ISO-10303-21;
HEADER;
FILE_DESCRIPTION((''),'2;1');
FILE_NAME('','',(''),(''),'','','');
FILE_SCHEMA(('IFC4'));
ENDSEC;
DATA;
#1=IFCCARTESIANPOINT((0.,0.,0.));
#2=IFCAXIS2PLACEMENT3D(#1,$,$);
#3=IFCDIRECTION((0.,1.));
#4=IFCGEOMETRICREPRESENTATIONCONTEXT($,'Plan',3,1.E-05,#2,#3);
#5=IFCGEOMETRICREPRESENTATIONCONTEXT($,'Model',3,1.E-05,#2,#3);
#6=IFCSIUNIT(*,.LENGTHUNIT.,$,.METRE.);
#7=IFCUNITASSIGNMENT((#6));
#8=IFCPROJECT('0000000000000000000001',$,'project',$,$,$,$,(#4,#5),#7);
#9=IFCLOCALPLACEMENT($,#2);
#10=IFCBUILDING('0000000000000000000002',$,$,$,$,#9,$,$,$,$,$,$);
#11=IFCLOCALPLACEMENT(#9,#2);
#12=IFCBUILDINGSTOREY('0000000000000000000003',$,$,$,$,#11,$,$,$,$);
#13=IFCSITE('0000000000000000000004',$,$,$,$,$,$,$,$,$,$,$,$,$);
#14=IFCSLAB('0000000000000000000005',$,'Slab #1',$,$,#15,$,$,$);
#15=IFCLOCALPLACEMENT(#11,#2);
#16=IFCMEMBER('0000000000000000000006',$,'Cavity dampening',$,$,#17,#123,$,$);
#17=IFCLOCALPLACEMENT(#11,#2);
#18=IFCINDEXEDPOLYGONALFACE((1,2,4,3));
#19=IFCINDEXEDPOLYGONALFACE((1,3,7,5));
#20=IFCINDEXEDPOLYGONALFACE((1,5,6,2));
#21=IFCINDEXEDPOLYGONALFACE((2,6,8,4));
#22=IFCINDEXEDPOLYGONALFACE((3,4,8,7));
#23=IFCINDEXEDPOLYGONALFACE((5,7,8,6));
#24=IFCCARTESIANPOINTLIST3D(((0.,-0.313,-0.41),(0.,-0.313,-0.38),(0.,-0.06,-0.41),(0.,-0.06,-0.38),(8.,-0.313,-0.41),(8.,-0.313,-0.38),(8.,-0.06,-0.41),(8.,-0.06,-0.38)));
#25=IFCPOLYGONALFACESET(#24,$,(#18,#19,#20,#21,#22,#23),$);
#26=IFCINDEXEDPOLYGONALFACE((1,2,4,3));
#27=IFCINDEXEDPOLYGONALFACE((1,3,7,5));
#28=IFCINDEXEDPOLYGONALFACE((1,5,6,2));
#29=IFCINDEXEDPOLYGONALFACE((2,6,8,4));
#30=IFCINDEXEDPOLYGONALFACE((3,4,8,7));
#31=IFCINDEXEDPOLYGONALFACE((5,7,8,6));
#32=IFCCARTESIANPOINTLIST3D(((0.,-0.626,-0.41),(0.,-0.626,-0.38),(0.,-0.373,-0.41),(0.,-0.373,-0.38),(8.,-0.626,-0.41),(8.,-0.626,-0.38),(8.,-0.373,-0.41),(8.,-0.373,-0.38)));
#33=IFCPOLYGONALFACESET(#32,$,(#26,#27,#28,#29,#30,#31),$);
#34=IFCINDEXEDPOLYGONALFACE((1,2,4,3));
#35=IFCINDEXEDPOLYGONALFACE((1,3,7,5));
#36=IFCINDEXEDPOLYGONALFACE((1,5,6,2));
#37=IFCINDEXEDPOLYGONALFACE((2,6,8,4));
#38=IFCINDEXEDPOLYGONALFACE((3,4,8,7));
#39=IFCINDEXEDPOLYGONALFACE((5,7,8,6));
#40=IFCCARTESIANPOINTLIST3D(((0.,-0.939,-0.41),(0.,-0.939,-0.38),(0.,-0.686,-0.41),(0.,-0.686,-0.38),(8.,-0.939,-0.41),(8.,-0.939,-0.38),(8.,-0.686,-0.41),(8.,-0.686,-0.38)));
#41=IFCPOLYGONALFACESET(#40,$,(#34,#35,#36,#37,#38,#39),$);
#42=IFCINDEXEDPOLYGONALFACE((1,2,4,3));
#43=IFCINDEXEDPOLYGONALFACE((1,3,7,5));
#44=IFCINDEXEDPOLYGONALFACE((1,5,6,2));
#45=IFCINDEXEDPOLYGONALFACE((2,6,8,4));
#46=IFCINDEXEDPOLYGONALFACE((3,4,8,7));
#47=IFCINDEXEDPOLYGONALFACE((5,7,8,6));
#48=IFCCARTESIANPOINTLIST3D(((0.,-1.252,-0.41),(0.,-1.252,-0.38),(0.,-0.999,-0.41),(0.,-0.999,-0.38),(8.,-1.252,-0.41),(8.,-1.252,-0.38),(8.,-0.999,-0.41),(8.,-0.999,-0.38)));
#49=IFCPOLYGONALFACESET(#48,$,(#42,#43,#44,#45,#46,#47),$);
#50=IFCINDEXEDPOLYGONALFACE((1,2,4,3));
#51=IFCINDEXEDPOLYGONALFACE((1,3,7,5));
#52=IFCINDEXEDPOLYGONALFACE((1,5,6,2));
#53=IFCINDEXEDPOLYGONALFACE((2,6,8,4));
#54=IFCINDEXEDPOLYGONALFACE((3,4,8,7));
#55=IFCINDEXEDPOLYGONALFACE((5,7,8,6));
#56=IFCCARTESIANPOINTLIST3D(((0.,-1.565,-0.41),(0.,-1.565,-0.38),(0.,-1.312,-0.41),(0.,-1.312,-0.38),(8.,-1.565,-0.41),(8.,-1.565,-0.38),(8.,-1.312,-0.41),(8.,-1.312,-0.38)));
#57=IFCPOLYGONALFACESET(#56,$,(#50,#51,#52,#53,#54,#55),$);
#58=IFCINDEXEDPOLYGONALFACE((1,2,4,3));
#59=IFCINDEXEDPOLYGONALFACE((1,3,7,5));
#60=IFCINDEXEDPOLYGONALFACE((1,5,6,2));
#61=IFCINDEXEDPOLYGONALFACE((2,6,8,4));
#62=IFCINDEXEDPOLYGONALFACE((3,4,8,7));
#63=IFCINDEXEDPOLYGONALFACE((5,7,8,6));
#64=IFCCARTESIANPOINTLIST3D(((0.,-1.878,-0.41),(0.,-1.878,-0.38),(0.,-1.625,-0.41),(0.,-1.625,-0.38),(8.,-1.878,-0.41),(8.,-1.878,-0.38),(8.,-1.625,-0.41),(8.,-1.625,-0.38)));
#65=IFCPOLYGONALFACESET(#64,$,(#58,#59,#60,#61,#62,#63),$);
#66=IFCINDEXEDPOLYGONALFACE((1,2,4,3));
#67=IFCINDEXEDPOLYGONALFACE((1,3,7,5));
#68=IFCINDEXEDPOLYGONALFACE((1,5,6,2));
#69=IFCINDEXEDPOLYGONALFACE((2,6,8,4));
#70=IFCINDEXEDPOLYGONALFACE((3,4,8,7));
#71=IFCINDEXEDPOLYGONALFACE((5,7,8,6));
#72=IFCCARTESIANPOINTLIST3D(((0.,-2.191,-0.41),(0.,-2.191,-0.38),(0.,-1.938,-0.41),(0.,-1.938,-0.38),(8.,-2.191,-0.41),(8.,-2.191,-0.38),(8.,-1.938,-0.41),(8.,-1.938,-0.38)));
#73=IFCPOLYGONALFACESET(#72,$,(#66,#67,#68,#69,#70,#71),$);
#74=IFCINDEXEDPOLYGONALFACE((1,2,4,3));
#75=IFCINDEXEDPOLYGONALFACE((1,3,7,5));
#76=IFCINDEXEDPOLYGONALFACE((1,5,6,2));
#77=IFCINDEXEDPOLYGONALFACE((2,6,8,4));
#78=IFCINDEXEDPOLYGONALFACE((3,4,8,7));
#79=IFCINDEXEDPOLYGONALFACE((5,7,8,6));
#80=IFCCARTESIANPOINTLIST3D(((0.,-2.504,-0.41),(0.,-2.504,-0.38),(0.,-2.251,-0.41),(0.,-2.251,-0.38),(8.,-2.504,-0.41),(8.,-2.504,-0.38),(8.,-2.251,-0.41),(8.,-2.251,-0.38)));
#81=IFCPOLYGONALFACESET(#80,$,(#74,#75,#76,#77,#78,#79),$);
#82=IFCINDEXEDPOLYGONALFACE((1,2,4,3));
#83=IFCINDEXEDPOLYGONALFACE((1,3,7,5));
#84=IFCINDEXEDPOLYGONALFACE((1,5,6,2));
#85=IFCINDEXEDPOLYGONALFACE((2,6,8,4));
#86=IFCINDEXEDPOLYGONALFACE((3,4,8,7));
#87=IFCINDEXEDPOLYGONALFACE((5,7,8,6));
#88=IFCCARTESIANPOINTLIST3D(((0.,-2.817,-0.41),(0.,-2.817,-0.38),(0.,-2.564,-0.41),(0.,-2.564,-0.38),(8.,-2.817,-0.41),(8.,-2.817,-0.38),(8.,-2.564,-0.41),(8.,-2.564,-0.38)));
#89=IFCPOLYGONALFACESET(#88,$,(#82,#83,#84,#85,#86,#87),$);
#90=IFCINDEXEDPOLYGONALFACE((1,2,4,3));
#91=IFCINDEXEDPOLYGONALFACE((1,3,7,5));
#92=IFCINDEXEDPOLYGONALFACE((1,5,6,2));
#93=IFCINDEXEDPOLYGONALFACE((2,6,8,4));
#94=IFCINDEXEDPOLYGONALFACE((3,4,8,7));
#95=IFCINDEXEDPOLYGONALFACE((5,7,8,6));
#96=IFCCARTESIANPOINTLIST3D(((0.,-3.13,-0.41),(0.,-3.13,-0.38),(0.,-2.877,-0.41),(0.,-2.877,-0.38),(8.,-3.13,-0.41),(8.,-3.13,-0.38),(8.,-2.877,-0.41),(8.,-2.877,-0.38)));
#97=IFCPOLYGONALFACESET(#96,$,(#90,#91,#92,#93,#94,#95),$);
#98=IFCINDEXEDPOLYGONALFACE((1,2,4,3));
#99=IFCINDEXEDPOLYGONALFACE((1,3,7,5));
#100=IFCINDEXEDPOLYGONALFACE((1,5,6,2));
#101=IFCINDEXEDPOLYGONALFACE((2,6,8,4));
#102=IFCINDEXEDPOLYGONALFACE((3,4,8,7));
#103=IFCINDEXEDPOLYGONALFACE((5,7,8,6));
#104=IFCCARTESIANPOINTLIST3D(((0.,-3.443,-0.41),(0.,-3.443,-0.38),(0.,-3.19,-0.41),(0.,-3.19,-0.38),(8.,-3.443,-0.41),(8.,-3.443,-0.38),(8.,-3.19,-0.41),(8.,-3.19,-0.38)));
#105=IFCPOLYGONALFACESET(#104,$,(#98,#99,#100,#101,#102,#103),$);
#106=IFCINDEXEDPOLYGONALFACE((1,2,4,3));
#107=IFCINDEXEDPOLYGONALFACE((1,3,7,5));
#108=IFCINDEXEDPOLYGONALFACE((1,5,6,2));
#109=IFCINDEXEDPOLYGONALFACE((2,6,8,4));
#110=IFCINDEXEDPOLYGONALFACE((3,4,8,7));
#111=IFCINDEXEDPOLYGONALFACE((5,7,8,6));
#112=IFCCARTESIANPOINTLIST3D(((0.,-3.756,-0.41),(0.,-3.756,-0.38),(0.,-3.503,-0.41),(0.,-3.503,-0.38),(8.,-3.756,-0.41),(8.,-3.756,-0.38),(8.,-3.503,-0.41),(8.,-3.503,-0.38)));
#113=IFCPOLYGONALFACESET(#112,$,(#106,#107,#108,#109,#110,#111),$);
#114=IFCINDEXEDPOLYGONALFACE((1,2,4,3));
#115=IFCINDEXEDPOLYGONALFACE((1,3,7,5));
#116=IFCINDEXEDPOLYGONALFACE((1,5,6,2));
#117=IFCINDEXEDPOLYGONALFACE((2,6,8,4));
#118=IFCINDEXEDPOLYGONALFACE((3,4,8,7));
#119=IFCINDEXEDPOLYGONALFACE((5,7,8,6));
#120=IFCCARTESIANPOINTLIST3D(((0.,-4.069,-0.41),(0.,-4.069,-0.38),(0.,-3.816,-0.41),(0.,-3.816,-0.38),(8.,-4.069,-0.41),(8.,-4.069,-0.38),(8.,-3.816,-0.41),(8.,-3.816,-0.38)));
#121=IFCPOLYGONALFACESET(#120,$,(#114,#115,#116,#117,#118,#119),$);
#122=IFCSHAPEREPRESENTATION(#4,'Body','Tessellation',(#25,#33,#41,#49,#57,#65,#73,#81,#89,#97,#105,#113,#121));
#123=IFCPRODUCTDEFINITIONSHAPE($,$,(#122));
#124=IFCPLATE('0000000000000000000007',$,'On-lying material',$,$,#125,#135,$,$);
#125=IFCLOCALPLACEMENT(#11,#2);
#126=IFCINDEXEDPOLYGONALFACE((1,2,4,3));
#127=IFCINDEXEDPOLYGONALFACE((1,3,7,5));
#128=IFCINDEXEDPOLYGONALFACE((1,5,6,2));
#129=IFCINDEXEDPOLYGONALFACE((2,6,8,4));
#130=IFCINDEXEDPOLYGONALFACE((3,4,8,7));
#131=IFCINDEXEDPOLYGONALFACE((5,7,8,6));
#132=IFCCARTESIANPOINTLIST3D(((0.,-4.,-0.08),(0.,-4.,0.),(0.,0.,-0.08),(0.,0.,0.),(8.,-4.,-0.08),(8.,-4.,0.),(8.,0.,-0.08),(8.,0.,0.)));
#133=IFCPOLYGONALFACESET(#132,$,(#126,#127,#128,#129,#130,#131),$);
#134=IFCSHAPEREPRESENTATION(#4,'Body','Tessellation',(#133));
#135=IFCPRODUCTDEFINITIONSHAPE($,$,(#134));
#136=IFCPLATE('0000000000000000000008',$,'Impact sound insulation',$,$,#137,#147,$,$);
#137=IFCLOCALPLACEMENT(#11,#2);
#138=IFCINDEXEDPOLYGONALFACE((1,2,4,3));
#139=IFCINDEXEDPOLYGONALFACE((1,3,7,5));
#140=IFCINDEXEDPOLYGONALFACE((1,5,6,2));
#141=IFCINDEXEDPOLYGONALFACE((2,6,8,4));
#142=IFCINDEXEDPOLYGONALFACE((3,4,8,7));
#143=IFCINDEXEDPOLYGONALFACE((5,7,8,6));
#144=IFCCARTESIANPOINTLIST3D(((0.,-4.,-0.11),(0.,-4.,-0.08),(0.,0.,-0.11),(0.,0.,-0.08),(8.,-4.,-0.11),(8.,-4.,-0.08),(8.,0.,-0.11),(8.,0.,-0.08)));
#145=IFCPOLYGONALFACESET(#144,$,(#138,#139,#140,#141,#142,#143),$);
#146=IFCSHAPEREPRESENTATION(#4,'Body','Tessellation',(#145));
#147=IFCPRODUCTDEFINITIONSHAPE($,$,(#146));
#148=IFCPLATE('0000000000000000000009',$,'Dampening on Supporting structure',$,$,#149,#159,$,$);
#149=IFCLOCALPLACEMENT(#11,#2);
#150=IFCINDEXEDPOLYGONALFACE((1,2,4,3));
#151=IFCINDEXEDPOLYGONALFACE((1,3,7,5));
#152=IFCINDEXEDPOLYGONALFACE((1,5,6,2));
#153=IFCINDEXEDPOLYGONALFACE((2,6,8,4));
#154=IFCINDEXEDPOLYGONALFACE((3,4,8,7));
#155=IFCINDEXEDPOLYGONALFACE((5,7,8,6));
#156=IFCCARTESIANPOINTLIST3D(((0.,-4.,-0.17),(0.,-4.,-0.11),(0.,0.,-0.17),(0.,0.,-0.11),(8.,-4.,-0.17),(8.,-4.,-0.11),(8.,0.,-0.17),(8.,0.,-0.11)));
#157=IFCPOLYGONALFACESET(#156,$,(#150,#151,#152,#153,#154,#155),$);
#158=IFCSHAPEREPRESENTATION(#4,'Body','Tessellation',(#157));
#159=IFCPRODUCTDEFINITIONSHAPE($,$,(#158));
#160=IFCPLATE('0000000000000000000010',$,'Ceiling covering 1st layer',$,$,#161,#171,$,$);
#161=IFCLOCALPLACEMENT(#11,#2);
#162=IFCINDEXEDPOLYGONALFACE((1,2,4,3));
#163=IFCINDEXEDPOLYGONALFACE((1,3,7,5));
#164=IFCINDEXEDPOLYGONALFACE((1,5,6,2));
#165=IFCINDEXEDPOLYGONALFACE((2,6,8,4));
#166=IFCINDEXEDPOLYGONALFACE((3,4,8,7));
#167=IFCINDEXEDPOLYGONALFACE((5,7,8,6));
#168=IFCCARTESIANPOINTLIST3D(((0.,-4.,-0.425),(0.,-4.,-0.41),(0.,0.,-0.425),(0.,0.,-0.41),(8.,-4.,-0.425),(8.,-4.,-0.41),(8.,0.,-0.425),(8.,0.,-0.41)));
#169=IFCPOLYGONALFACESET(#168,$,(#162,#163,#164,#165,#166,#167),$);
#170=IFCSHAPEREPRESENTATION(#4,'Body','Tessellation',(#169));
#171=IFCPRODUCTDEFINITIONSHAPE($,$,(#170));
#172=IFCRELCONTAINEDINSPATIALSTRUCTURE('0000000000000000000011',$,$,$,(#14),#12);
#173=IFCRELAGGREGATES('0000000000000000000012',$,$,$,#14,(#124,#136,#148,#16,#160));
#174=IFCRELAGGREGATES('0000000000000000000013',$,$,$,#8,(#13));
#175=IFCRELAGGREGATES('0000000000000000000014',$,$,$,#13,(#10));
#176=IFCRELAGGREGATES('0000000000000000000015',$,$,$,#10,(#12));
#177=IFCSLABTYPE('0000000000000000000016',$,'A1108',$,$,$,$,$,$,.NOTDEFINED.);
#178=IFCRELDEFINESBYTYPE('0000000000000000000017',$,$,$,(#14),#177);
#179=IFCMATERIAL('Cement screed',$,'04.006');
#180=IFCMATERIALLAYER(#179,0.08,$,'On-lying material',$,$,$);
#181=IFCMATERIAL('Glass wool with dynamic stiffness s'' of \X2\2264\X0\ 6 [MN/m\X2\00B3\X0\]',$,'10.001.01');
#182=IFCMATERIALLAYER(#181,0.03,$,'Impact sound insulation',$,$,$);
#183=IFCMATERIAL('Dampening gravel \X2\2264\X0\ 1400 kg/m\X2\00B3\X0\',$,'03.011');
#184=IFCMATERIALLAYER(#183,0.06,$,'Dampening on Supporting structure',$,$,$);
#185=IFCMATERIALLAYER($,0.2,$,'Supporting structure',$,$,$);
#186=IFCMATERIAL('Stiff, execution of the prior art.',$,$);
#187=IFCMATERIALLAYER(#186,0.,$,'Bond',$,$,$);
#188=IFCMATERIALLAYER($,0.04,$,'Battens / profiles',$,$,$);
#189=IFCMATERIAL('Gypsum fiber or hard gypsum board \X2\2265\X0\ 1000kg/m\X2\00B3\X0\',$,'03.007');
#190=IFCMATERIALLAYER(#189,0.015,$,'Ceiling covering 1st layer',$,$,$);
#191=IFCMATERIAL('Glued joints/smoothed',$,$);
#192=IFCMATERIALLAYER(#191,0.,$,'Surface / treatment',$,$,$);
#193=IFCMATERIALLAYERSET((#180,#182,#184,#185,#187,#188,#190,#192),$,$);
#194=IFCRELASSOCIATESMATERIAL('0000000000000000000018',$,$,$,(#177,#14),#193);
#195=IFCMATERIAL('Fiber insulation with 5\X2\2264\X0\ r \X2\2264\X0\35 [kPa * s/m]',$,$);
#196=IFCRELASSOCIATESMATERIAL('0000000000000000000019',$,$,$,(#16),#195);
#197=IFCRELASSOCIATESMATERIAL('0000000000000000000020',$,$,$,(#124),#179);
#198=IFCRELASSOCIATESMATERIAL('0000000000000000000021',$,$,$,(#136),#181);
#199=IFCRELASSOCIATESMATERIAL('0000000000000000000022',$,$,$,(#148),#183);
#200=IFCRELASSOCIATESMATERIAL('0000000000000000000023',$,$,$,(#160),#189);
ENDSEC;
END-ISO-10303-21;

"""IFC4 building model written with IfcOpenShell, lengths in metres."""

from ifc_helpers import new_model, si_unit, direction, frame, frame_2d, origin, origin_with_axes, place, context, project, spatial, rectangle, extrude, material, layer, layer_set, type_object, element, aggregate, save


model = new_model("IFC4")

# Units and contexts
plan_context = context("Plan", 3, precision=1e-05, world=origin(), true_north=direction((0.0, 1.0)))
model_context = context("Model", 3, precision=1e-05, world=origin(), true_north=direction((0.0, 1.0)))
ifc_project = project(units=[si_unit("LENGTHUNIT", "METRE")], contexts=[plan_context, model_context])

# Site, building, storey
site = spatial("IfcSite", under=ifc_project)
building_placement = place(None, origin())
building = spatial("IfcBuilding", under=site, at=building_placement)
storey_placement = place(building_placement, origin())
storey = spatial("IfcBuildingStorey", under=building, at=storey_placement)

# Slab, member, plates
ifc_material_1 = material(Name="Cement screed", Category="04.006")
ifc_layer_1 = layer(ifc_material_1, 0.08, Name="On-lying material")
ifc_material_2 = material(Name="Glass wool with dynamic stiffness s' of ≤ 6 [MN/m³]", Category="10.001.01")
ifc_layer_2 = layer(ifc_material_2, 0.03, Name="Impact sound insulation")
ifc_material_3 = material(Name="Dampening gravel ≤ 1400 kg/m³", Category="03.011")
ifc_layer_3 = layer(ifc_material_3, 0.06, Name="Dampening on Supporting structure")
ifc_layer_4 = layer(None, 0.2, Name="Supporting structure")
ifc_material_4 = material(Name="Stiff, execution of the prior art.")
ifc_layer_5 = layer(ifc_material_4, 0.0, Name="Bond")
ifc_layer_6 = layer(None, 0.04, Name="Battens / profiles")
ifc_material_5 = material(Name="Gypsum fiber or hard gypsum board ≥ 1000kg/m³", Category="03.007")
ifc_layer_7 = layer(ifc_material_5, 0.015, Name="Ceiling covering 1st layer")
ifc_material_6 = material(Name="Glued joints/smoothed")
ifc_layer_8 = layer(ifc_material_6, 0.0, Name="Surface / treatment")
ifc_layer_set = layer_set([ifc_layer_1, ifc_layer_2, ifc_layer_3, ifc_layer_4, ifc_layer_5, ifc_layer_6, ifc_layer_7, ifc_layer_8])
slab_type = type_object("IfcSlabType", Name="A1108", PredefinedType="NOTDEFINED", material=ifc_layer_set)
slab_placement = place(None, frame((0.0, 0.0, 0.0), z_axis=(0.0, 0.0, -1.0), x_axis=(1.0, 0.0, 0.0)))
slab = element("IfcSlab", 1, at=slab_placement, inside=storey, type_object=slab_type, material=ifc_layer_set, Name="Slab #1")
ifc_material_7 = material(Name="Fiber insulation with 5≤ r ≤35 [kPa * s/m]")
member_1_placement = place(slab_placement, origin())
member_1 = element("IfcMember", 2, at=member_1_placement, material=ifc_material_7, Name="Cavity dampening", context=plan_context, shape_type="SweptSolid", body=[
    extrude(rectangle(XDim=0.253, YDim=0.03, at=frame_2d((0.1265, 0.015), x_axis=(1.0, 0.0))), frame((0.0, 0.06, 0.38), z_axis=(1.0, 0.0, 0.0), x_axis=(0.0, 1.0, 0.0)), (0.0, 0.0, 1.0), 8.0),
    extrude(rectangle(XDim=0.253, YDim=0.03, at=frame_2d((0.1265, 0.015), x_axis=(1.0, 0.0))), frame((0.0, 0.373, 0.38), z_axis=(1.0, 0.0, 0.0), x_axis=(0.0, 1.0, 0.0)), (0.0, 0.0, 1.0), 8.0),
    extrude(rectangle(XDim=0.253, YDim=0.03, at=frame_2d((0.1265, 0.015), x_axis=(1.0, 0.0))), frame((0.0, 0.686, 0.38), z_axis=(1.0, 0.0, 0.0), x_axis=(0.0, 1.0, 0.0)), (0.0, 0.0, 1.0), 8.0),
    extrude(rectangle(XDim=0.253, YDim=0.03, at=frame_2d((0.1265, 0.015), x_axis=(1.0, 0.0))), frame((0.0, 0.999, 0.38), z_axis=(1.0, 0.0, 0.0), x_axis=(0.0, 1.0, 0.0)), (0.0, 0.0, 1.0), 8.0),
    extrude(rectangle(XDim=0.253, YDim=0.03, at=frame_2d((0.1265, 0.015), x_axis=(1.0, 0.0))), frame((0.0, 1.312, 0.38), z_axis=(1.0, 0.0, 0.0), x_axis=(0.0, 1.0, 0.0)), (0.0, 0.0, 1.0), 8.0),
    extrude(rectangle(XDim=0.253, YDim=0.03, at=frame_2d((0.1265, 0.015), x_axis=(1.0, 0.0))), frame((0.0, 1.625, 0.38), z_axis=(1.0, 0.0, 0.0), x_axis=(0.0, 1.0, 0.0)), (0.0, 0.0, 1.0), 8.0),
    extrude(rectangle(XDim=0.253, YDim=0.03, at=frame_2d((0.1265, 0.015), x_axis=(1.0, 0.0))), frame((0.0, 1.938, 0.38), z_axis=(1.0, 0.0, 0.0), x_axis=(0.0, 1.0, 0.0)), (0.0, 0.0, 1.0), 8.0),
    extrude(rectangle(XDim=0.253, YDim=0.03, at=frame_2d((0.1265, 0.015), x_axis=(1.0, 0.0))), frame((0.0, 2.251, 0.38), z_axis=(1.0, 0.0, 0.0), x_axis=(0.0, 1.0, 0.0)), (0.0, 0.0, 1.0), 8.0),
    extrude(rectangle(XDim=0.253, YDim=0.03, at=frame_2d((0.1265, 0.015), x_axis=(1.0, 0.0))), frame((0.0, 2.564, 0.38), z_axis=(1.0, 0.0, 0.0), x_axis=(0.0, 1.0, 0.0)), (0.0, 0.0, 1.0), 8.0),
    extrude(rectangle(XDim=0.253, YDim=0.03, at=frame_2d((0.1265, 0.015), x_axis=(1.0, 0.0))), frame((0.0, 2.877, 0.38), z_axis=(1.0, 0.0, 0.0), x_axis=(0.0, 1.0, 0.0)), (0.0, 0.0, 1.0), 8.0),
    extrude(rectangle(XDim=0.253, YDim=0.03, at=frame_2d((0.1265, 0.015), x_axis=(1.0, 0.0))), frame((0.0, 3.19, 0.38), z_axis=(1.0, 0.0, 0.0), x_axis=(0.0, 1.0, 0.0)), (0.0, 0.0, 1.0), 8.0),
    extrude(rectangle(XDim=0.253, YDim=0.03, at=frame_2d((0.1265, 0.015), x_axis=(1.0, 0.0))), frame((0.0, 3.503, 0.38), z_axis=(1.0, 0.0, 0.0), x_axis=(0.0, 1.0, 0.0)), (0.0, 0.0, 1.0), 8.0),
    extrude(rectangle(XDim=0.253, YDim=0.03, at=frame_2d((0.1265, 0.015), x_axis=(1.0, 0.0))), frame((0.0, 3.816, 0.38), z_axis=(1.0, 0.0, 0.0), x_axis=(0.0, 1.0, 0.0)), (0.0, 0.0, 1.0), 8.0),
])
plate_1_placement = place(slab_placement, origin())
plate_1 = element("IfcPlate", 3, at=plate_1_placement, material=ifc_material_1, Name="On-lying material", context=plan_context, shape_type="SweptSolid", body=[
    extrude(rectangle(XDim=8.0, YDim=4.0, at=frame_2d((4.0, 2.0), x_axis=(1.0, 0.0))), origin_with_axes(), (0.0, 0.0, 1.0), 0.08),
])
plate_2_placement = place(slab_placement, origin())
plate_2 = element("IfcPlate", 4, at=plate_2_placement, material=ifc_material_2, Name="Impact sound insulation", context=plan_context, shape_type="SweptSolid", body=[
    extrude(rectangle(XDim=8.0, YDim=4.0, at=frame_2d((4.0, 2.0), x_axis=(1.0, 0.0))), frame((0.0, 0.0, 0.08), z_axis=(0.0, 0.0, 1.0), x_axis=(1.0, 0.0, 0.0)), (0.0, 0.0, 1.0), 0.03),
])
plate_3_placement = place(slab_placement, origin())
plate_3 = element("IfcPlate", 5, at=plate_3_placement, material=ifc_material_3, Name="Dampening on Supporting structure", context=plan_context, shape_type="SweptSolid", body=[
    extrude(rectangle(XDim=8.0, YDim=4.0, at=frame_2d((4.0, 2.0), x_axis=(1.0, 0.0))), frame((0.0, 0.0, 0.11), z_axis=(0.0, 0.0, 1.0), x_axis=(1.0, 0.0, 0.0)), (0.0, 0.0, 1.0), 0.06),
])
plate_4_placement = place(slab_placement, origin())
plate_4 = element("IfcPlate", 6, at=plate_4_placement, material=ifc_material_5, Name="Ceiling covering 1st layer", context=plan_context, shape_type="SweptSolid", body=[
    extrude(rectangle(XDim=8.0, YDim=4.0, at=frame_2d((4.0, 2.0), x_axis=(1.0, 0.0))), frame((0.0, 0.0, 0.41), z_axis=(0.0, 0.0, 1.0), x_axis=(1.0, 0.0, 0.0)), (0.0, 0.0, 1.0), 0.015),
])
aggregate(slab, [plate_1, plate_2, plate_3, member_1, plate_4])

save(model, "model.ifc")
